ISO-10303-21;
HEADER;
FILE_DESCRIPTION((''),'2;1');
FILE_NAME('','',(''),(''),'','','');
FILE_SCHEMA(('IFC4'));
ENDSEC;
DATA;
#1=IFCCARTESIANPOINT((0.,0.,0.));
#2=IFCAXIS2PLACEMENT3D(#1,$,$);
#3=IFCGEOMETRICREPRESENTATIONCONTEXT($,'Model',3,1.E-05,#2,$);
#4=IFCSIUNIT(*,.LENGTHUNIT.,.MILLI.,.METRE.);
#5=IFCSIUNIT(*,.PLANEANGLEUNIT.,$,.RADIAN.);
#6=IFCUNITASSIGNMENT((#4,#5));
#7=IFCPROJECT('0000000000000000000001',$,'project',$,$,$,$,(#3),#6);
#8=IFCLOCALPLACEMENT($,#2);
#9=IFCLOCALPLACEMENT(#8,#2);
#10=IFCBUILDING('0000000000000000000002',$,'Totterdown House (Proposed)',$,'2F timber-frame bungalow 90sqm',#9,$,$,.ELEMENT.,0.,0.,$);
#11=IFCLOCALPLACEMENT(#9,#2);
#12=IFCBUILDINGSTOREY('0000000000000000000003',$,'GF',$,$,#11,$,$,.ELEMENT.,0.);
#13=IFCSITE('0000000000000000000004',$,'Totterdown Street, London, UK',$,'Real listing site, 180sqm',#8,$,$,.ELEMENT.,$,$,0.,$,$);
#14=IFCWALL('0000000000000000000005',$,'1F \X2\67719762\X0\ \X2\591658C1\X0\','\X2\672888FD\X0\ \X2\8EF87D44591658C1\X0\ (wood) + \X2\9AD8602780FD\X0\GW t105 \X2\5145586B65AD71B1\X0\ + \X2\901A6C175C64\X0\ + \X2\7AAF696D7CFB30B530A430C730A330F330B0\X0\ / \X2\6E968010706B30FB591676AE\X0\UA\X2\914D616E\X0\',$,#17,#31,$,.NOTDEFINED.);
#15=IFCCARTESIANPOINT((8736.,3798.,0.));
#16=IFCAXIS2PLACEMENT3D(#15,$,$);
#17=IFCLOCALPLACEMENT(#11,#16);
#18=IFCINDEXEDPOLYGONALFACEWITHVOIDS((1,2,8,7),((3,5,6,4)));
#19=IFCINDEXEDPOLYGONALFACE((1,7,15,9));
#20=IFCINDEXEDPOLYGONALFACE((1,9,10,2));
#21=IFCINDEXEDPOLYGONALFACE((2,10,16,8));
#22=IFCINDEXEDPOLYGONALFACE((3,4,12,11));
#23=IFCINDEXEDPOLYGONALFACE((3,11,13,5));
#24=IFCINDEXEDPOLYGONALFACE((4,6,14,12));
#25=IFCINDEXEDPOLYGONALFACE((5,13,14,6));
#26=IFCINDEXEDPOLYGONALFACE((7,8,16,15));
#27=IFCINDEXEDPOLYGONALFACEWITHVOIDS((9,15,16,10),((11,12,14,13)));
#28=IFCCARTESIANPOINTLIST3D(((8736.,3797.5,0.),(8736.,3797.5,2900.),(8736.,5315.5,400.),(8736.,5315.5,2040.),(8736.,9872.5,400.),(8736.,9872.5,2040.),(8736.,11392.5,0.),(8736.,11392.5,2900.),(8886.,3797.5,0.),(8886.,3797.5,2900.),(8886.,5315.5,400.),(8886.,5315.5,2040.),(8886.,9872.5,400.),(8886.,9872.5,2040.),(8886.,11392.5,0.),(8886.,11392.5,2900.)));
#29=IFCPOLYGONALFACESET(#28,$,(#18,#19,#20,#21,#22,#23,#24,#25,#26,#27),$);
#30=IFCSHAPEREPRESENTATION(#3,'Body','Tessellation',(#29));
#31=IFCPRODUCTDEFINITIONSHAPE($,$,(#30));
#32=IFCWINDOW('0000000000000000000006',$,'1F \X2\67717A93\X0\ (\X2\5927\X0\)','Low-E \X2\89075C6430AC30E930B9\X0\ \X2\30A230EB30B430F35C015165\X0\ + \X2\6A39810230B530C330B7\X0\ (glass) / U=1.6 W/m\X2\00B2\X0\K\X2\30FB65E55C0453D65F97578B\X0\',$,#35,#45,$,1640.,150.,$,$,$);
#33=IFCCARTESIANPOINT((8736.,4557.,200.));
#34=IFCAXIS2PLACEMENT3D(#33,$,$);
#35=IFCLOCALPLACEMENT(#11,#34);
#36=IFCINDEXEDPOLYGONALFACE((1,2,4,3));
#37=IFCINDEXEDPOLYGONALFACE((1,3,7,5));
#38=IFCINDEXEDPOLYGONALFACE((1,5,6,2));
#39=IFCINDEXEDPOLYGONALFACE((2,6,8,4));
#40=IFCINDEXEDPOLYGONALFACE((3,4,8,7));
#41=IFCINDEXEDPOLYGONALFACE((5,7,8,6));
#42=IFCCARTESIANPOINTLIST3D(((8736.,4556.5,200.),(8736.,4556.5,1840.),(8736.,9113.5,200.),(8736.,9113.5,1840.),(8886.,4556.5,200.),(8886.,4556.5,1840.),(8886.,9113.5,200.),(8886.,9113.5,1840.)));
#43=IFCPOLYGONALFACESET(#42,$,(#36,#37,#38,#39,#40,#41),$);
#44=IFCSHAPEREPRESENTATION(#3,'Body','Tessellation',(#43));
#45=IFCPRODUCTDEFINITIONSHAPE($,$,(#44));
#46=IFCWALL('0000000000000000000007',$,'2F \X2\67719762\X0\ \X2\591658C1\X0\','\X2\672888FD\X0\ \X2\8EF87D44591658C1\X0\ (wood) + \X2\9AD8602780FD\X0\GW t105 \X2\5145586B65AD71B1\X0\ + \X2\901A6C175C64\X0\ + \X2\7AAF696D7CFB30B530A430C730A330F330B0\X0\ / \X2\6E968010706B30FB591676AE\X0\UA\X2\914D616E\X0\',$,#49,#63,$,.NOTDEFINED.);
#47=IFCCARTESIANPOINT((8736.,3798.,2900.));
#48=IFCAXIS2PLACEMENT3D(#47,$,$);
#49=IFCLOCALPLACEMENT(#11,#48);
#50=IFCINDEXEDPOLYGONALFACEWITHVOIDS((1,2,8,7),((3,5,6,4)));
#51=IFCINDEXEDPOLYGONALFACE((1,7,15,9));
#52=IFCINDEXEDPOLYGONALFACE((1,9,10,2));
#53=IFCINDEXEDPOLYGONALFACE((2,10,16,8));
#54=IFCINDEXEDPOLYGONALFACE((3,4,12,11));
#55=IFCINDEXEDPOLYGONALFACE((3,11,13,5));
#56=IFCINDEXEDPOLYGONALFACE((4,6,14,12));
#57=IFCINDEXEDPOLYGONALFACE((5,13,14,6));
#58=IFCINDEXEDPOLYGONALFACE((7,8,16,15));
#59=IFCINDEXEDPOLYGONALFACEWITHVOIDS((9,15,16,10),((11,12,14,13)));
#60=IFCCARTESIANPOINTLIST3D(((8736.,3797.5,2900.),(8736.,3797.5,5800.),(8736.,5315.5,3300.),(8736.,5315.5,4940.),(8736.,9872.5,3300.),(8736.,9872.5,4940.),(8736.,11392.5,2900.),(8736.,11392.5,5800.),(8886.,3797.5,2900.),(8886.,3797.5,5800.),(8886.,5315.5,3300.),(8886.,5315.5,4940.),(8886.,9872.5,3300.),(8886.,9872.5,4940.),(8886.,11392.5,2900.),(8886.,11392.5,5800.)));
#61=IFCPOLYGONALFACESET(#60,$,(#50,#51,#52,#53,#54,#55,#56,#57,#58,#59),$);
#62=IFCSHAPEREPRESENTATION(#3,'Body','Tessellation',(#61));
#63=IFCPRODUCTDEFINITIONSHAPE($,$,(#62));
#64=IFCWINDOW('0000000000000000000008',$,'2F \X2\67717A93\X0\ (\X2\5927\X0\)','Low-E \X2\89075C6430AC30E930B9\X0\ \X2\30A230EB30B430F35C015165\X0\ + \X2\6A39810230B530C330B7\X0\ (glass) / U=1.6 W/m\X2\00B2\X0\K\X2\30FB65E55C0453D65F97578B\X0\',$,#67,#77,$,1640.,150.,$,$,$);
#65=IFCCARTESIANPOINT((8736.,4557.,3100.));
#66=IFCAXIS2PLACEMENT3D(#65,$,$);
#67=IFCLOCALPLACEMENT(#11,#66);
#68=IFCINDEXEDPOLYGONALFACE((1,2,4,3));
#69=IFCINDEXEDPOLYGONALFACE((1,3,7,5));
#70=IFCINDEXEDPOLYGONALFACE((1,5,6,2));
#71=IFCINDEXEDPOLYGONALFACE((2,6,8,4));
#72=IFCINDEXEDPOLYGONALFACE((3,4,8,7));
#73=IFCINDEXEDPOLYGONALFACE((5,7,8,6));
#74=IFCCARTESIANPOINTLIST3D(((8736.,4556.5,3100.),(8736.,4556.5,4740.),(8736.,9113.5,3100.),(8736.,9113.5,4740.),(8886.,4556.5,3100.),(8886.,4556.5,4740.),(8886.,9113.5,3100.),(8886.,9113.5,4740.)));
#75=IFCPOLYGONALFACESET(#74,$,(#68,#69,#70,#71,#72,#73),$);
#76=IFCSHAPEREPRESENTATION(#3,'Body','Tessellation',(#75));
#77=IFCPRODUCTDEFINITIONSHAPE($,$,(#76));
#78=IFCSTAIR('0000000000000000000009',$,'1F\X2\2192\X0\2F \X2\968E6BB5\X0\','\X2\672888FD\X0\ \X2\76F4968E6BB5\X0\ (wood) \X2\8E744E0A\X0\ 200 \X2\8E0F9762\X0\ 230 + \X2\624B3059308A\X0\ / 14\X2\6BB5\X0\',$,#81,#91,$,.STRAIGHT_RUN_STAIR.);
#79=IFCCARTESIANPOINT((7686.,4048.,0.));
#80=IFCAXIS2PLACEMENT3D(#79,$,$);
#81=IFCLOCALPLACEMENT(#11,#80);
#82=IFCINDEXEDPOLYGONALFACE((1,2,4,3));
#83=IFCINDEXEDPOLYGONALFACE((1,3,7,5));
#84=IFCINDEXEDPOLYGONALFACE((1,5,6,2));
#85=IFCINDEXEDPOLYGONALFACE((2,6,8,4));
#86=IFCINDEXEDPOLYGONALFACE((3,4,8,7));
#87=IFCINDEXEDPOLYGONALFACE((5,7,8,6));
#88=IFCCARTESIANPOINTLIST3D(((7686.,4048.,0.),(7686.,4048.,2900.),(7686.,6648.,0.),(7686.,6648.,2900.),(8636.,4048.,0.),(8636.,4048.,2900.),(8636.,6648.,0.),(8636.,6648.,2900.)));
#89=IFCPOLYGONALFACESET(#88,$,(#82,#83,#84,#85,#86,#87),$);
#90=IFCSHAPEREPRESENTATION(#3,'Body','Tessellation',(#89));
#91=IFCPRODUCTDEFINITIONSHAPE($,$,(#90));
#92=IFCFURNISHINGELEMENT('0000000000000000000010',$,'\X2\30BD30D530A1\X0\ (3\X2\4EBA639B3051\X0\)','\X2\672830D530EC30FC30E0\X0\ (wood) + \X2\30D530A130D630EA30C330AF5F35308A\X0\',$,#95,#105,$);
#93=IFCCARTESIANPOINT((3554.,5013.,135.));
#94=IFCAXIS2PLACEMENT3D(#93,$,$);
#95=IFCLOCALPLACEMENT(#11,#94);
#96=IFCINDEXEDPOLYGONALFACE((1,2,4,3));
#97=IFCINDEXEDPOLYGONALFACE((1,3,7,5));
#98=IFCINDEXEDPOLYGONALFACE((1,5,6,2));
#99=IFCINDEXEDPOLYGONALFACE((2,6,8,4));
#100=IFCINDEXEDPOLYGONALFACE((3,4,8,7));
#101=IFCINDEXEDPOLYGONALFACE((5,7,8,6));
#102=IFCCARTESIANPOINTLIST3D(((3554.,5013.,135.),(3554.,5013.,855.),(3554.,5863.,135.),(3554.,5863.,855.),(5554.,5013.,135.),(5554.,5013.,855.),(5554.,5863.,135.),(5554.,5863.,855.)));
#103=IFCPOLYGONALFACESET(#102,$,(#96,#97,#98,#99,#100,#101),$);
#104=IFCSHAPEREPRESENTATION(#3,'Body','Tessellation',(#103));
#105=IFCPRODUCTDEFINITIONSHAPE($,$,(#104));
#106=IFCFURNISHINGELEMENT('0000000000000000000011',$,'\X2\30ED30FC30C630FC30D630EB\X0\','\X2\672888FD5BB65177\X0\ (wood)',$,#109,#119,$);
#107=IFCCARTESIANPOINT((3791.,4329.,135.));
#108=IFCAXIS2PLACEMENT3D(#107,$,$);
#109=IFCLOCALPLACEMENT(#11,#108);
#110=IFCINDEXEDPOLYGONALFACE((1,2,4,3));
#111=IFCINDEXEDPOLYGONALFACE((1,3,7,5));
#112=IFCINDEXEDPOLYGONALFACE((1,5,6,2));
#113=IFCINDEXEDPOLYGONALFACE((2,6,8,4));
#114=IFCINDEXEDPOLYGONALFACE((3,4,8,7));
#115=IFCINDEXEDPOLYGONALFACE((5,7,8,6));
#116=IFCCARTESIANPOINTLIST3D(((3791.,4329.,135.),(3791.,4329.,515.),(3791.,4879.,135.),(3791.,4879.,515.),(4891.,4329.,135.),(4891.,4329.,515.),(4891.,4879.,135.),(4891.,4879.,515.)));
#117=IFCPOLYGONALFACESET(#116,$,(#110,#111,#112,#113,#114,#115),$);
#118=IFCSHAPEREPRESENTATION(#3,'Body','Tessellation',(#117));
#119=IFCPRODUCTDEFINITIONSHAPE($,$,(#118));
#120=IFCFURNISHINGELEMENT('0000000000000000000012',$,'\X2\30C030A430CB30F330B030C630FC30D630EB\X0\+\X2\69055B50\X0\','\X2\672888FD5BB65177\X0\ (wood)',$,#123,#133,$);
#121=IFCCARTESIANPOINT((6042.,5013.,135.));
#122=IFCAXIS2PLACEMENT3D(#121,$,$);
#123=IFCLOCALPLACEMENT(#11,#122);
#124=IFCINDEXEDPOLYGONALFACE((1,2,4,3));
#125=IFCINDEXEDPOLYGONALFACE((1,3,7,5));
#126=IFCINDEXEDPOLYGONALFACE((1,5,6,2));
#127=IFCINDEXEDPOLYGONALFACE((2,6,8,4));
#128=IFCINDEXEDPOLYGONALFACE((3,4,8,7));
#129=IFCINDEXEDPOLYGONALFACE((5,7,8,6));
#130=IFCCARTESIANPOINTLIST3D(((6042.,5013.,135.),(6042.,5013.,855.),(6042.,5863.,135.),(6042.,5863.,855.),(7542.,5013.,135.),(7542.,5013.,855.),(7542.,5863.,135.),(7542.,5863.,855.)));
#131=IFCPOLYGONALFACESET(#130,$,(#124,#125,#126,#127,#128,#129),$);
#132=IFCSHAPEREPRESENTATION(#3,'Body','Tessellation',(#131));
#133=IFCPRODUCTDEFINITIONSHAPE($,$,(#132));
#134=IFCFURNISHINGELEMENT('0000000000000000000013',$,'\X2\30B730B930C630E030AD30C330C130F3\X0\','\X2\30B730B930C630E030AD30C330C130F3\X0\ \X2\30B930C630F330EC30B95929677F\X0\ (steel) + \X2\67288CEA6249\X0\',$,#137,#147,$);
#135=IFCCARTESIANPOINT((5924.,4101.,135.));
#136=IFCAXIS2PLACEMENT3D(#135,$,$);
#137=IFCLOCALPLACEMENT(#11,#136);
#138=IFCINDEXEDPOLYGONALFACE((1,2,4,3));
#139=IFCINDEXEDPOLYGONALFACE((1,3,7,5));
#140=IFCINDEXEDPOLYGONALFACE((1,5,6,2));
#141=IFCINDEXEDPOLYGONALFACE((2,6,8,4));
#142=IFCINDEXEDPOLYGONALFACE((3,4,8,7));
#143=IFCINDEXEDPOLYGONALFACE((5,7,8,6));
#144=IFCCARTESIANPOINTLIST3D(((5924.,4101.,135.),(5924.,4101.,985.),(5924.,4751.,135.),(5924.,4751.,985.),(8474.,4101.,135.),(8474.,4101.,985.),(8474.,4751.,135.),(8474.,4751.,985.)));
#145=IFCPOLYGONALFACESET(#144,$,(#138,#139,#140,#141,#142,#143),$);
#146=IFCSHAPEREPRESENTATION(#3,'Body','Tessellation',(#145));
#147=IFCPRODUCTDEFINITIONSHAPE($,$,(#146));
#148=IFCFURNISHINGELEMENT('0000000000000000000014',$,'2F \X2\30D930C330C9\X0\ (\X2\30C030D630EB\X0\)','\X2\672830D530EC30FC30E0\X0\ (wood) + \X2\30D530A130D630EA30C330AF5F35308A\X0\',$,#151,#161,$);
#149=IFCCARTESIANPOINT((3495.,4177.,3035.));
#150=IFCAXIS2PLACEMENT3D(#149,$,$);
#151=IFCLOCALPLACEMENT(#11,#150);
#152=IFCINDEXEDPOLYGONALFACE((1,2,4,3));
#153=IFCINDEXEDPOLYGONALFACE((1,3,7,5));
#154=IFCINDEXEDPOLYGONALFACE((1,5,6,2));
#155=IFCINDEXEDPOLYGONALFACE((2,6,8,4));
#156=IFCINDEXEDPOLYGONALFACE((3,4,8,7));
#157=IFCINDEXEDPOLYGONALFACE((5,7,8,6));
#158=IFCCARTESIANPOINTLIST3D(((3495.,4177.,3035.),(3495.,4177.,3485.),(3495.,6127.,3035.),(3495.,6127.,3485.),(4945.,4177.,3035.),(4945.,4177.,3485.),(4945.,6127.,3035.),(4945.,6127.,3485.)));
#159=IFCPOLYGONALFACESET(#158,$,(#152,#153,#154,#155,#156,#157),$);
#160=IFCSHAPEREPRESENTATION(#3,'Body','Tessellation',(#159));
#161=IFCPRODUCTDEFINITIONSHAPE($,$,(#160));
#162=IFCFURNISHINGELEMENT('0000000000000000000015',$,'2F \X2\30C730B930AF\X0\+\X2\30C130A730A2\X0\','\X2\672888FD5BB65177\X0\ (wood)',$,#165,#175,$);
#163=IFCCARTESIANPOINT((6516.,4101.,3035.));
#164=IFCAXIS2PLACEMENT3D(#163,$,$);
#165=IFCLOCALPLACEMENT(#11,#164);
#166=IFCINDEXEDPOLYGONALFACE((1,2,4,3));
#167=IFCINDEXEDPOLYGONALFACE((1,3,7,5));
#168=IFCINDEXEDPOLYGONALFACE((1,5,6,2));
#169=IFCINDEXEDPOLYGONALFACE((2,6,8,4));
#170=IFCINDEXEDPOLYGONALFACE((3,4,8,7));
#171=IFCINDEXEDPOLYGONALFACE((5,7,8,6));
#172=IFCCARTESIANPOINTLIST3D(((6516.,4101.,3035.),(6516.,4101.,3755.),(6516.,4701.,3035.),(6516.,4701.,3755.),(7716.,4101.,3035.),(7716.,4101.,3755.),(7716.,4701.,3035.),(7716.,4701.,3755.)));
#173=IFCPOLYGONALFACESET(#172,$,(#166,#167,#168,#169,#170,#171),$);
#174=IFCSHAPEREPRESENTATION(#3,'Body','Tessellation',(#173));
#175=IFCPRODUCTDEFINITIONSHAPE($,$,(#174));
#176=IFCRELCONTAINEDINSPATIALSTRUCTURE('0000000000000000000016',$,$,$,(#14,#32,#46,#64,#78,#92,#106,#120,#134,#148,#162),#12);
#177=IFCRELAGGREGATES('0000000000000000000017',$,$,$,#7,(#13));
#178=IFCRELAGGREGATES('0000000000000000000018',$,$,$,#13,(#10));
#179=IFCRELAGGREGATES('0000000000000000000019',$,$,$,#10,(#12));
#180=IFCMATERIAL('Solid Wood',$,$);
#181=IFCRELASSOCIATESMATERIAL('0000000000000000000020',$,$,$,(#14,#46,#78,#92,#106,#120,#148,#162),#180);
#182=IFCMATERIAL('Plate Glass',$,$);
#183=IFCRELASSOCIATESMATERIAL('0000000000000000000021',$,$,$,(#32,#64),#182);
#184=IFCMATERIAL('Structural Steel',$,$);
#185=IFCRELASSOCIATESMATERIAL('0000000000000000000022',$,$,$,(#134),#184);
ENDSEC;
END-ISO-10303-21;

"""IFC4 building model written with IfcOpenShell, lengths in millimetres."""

from ifc_helpers import new_model, si_unit, frame, frame_2d, origin, place, context, project, spatial, rectangle, extrude, material, element, fill, save


model = new_model("IFC4")

# Units and contexts
model_context = context("Model", 3, precision=1e-05, world=origin())
ifc_project = project(units=[si_unit("LENGTHUNIT", "METRE", prefix="MILLI"), si_unit("PLANEANGLEUNIT", "RADIAN")], contexts=[model_context])

# Site, building, storey
site_placement = place(None, origin())
site = spatial("IfcSite", under=ifc_project, at=site_placement, Name="Totterdown Street, London, UK", ObjectType="Real listing site, 180sqm", CompositionType="ELEMENT", RefElevation=0.0)
building_placement = place(site_placement, origin())
building = spatial("IfcBuilding", under=site, at=building_placement, Name="Totterdown House (Proposed)", ObjectType="2F timber-frame bungalow 90sqm", CompositionType="ELEMENT", ElevationOfRefHeight=0.0, ElevationOfTerrain=0.0)
storey_placement = place(building_placement, origin())
storey = spatial("IfcBuildingStorey", under=building, at=storey_placement, Name="GF", CompositionType="ELEMENT", Elevation=0.0)

# Wall, opening, window
ifc_material_1 = material(Name="Solid Wood")
wall_1_placement = place(storey_placement, frame((8736.0, 3798.0, 0.0)))
wall_1 = element("IfcWall", 1, at=wall_1_placement, inside=storey, material=ifc_material_1, Name="1F 東面 外壁", Description="木製 軸組外壁 (wood) + 高性能GW t105 充填断熱 + 通気層 + 窯業系サイディング / 準耐火・外皮UA配慮", PredefinedType="NOTDEFINED", context=model_context, shape_type="SweptSolid", body=[
    extrude(rectangle(XDim=150.0, YDim=7595.0, at=frame_2d((75.0, 3797.0))), frame((8736.0, 3798.0, 0.0)), (0.0, 0.0, 1.0), 2900.0),
])
opening_1_placement = place(storey_placement, frame((8736.0, 4557.0, 200.0)))
opening_1 = element("IfcOpeningElement", 2, at=opening_1_placement, cuts=wall_1, PredefinedType="NOTDEFINED", context=model_context, shape_type="SweptSolid", body=[
    extrude(rectangle(XDim=150.0, YDim=4557.0, at=frame_2d((75.0, 2278.0))), frame((8736.0, 4557.0, 200.0)), (0.0, 0.0, 1.0), 1640.0),
])
ifc_material_2 = material(Name="Plate Glass")
window_1_placement = place(storey_placement, frame((8736.0, 4557.0, 200.0)))
window_1 = element("IfcWindow", 3, at=window_1_placement, inside=storey, material=ifc_material_2, Name="1F 東窓 (大)", Description="Low-E 複層ガラス アルゴン封入 + 樹脂サッシ (glass) / U=1.6 W/m²K・日射取得型", OverallHeight=1640.0, OverallWidth=150.0, context=model_context, shape_type="SweptSolid", body=[
    extrude(rectangle(XDim=150.0, YDim=4557.0, at=frame_2d((75.0, 2278.0))), frame((8736.0, 4557.0, 200.0)), (0.0, 0.0, 1.0), 1640.0),
])
fill(opening_1, window_1)

# Wall, opening, window
wall_2_placement = place(storey_placement, frame((8736.0, 3798.0, 2900.0)))
wall_2 = element("IfcWall", 4, at=wall_2_placement, inside=storey, material=ifc_material_1, Name="2F 東面 外壁", Description="木製 軸組外壁 (wood) + 高性能GW t105 充填断熱 + 通気層 + 窯業系サイディング / 準耐火・外皮UA配慮", PredefinedType="NOTDEFINED", context=model_context, shape_type="SweptSolid", body=[
    extrude(rectangle(XDim=150.0, YDim=7595.0, at=frame_2d((75.0, 3797.0))), frame((8736.0, 3798.0, 2900.0)), (0.0, 0.0, 1.0), 2900.0),
])
opening_2_placement = place(storey_placement, frame((8736.0, 4557.0, 3100.0)))
opening_2 = element("IfcOpeningElement", 5, at=opening_2_placement, cuts=wall_2, PredefinedType="NOTDEFINED", context=model_context, shape_type="SweptSolid", body=[
    extrude(rectangle(XDim=150.0, YDim=4557.0, at=frame_2d((75.0, 2278.0))), frame((8736.0, 4557.0, 3100.0)), (0.0, 0.0, 1.0), 1640.0),
])
window_2_placement = place(storey_placement, frame((8736.0, 4557.0, 3100.0)))
window_2 = element("IfcWindow", 6, at=window_2_placement, inside=storey, material=ifc_material_2, Name="2F 東窓 (大)", Description="Low-E 複層ガラス アルゴン封入 + 樹脂サッシ (glass) / U=1.6 W/m²K・日射取得型", OverallHeight=1640.0, OverallWidth=150.0, context=model_context, shape_type="SweptSolid", body=[
    extrude(rectangle(XDim=150.0, YDim=4557.0, at=frame_2d((75.0, 2278.0))), frame((8736.0, 4557.0, 3100.0)), (0.0, 0.0, 1.0), 1640.0),
])
fill(opening_2, window_2)

# Stair
stair_placement = place(storey_placement, frame((7686.0, 4048.0, 0.0)))
element("IfcStair", 7, at=stair_placement, inside=storey, material=ifc_material_1, Name="1F→2F 階段", Description="木製 直階段 (wood) 蹴上 200 踏面 230 + 手すり / 14段", PredefinedType="STRAIGHT_RUN_STAIR", context=model_context, shape_type="SweptSolid", body=[
    extrude(rectangle(XDim=950.0, YDim=2600.0, at=frame_2d((475.0, 1300.0))), frame((7686.0, 4048.0, 0.0)), (0.0, 0.0, 1.0), 2900.0),
])

# Furnishing elements
furnishing_1_placement = place(storey_placement, frame((3554.0, 5013.0, 135.0)))
element("IfcFurnishingElement", 8, at=furnishing_1_placement, inside=storey, material=ifc_material_1, Name="ソファ (3人掛け)", Description="木フレーム (wood) + ファブリック張り", context=model_context, shape_type="SweptSolid", body=[
    extrude(rectangle(XDim=2000.0, YDim=850.0, at=frame_2d((1000.0, 425.0))), frame((3554.0, 5013.0, 135.0)), (0.0, 0.0, 1.0), 720.0),
])
furnishing_2_placement = place(storey_placement, frame((3791.0, 4329.0, 135.0)))
element("IfcFurnishingElement", 9, at=furnishing_2_placement, inside=storey, material=ifc_material_1, Name="ローテーブル", Description="木製家具 (wood)", context=model_context, shape_type="SweptSolid", body=[
    extrude(rectangle(XDim=1100.0, YDim=550.0, at=frame_2d((550.0, 275.0))), frame((3791.0, 4329.0, 135.0)), (0.0, 0.0, 1.0), 380.0),
])
furnishing_3_placement = place(storey_placement, frame((6042.0, 5013.0, 135.0)))
element("IfcFurnishingElement", 10, at=furnishing_3_placement, inside=storey, material=ifc_material_1, Name="ダイニングテーブル+椅子", Description="木製家具 (wood)", context=model_context, shape_type="SweptSolid", body=[
    extrude(rectangle(XDim=1500.0, YDim=850.0, at=frame_2d((750.0, 425.0))), frame((6042.0, 5013.0, 135.0)), (0.0, 0.0, 1.0), 720.0),
])
ifc_material_3 = material(Name="Structural Steel")
furnishing_4_placement = place(storey_placement, frame((5924.0, 4101.0, 135.0)))
element("IfcFurnishingElement", 11, at=furnishing_4_placement, inside=storey, material=ifc_material_3, Name="システムキッチン", Description="システムキッチン ステンレス天板 (steel) + 木質扉", context=model_context, shape_type="SweptSolid", body=[
    extrude(rectangle(XDim=2550.0, YDim=650.0, at=frame_2d((1275.0, 325.0))), frame((5924.0, 4101.0, 135.0)), (0.0, 0.0, 1.0), 850.0),
])
furnishing_5_placement = place(storey_placement, frame((3495.0, 4177.0, 3035.0)))
element("IfcFurnishingElement", 12, at=furnishing_5_placement, inside=storey, material=ifc_material_1, Name="2F ベッド (ダブル)", Description="木フレーム (wood) + ファブリック張り", context=model_context, shape_type="SweptSolid", body=[
    extrude(rectangle(XDim=1450.0, YDim=1950.0, at=frame_2d((725.0, 975.0))), frame((3495.0, 4177.0, 3035.0)), (0.0, 0.0, 1.0), 450.0),
])
furnishing_6_placement = place(storey_placement, frame((6516.0, 4101.0, 3035.0)))
element("IfcFurnishingElement", 13, at=furnishing_6_placement, inside=storey, material=ifc_material_1, Name="2F デスク+チェア", Description="木製家具 (wood)", context=model_context, shape_type="SweptSolid", body=[
    extrude(rectangle(XDim=1200.0, YDim=600.0, at=frame_2d((600.0, 300.0))), frame((6516.0, 4101.0, 3035.0)), (0.0, 0.0, 1.0), 720.0),
])

save(model, "model.ifc")
